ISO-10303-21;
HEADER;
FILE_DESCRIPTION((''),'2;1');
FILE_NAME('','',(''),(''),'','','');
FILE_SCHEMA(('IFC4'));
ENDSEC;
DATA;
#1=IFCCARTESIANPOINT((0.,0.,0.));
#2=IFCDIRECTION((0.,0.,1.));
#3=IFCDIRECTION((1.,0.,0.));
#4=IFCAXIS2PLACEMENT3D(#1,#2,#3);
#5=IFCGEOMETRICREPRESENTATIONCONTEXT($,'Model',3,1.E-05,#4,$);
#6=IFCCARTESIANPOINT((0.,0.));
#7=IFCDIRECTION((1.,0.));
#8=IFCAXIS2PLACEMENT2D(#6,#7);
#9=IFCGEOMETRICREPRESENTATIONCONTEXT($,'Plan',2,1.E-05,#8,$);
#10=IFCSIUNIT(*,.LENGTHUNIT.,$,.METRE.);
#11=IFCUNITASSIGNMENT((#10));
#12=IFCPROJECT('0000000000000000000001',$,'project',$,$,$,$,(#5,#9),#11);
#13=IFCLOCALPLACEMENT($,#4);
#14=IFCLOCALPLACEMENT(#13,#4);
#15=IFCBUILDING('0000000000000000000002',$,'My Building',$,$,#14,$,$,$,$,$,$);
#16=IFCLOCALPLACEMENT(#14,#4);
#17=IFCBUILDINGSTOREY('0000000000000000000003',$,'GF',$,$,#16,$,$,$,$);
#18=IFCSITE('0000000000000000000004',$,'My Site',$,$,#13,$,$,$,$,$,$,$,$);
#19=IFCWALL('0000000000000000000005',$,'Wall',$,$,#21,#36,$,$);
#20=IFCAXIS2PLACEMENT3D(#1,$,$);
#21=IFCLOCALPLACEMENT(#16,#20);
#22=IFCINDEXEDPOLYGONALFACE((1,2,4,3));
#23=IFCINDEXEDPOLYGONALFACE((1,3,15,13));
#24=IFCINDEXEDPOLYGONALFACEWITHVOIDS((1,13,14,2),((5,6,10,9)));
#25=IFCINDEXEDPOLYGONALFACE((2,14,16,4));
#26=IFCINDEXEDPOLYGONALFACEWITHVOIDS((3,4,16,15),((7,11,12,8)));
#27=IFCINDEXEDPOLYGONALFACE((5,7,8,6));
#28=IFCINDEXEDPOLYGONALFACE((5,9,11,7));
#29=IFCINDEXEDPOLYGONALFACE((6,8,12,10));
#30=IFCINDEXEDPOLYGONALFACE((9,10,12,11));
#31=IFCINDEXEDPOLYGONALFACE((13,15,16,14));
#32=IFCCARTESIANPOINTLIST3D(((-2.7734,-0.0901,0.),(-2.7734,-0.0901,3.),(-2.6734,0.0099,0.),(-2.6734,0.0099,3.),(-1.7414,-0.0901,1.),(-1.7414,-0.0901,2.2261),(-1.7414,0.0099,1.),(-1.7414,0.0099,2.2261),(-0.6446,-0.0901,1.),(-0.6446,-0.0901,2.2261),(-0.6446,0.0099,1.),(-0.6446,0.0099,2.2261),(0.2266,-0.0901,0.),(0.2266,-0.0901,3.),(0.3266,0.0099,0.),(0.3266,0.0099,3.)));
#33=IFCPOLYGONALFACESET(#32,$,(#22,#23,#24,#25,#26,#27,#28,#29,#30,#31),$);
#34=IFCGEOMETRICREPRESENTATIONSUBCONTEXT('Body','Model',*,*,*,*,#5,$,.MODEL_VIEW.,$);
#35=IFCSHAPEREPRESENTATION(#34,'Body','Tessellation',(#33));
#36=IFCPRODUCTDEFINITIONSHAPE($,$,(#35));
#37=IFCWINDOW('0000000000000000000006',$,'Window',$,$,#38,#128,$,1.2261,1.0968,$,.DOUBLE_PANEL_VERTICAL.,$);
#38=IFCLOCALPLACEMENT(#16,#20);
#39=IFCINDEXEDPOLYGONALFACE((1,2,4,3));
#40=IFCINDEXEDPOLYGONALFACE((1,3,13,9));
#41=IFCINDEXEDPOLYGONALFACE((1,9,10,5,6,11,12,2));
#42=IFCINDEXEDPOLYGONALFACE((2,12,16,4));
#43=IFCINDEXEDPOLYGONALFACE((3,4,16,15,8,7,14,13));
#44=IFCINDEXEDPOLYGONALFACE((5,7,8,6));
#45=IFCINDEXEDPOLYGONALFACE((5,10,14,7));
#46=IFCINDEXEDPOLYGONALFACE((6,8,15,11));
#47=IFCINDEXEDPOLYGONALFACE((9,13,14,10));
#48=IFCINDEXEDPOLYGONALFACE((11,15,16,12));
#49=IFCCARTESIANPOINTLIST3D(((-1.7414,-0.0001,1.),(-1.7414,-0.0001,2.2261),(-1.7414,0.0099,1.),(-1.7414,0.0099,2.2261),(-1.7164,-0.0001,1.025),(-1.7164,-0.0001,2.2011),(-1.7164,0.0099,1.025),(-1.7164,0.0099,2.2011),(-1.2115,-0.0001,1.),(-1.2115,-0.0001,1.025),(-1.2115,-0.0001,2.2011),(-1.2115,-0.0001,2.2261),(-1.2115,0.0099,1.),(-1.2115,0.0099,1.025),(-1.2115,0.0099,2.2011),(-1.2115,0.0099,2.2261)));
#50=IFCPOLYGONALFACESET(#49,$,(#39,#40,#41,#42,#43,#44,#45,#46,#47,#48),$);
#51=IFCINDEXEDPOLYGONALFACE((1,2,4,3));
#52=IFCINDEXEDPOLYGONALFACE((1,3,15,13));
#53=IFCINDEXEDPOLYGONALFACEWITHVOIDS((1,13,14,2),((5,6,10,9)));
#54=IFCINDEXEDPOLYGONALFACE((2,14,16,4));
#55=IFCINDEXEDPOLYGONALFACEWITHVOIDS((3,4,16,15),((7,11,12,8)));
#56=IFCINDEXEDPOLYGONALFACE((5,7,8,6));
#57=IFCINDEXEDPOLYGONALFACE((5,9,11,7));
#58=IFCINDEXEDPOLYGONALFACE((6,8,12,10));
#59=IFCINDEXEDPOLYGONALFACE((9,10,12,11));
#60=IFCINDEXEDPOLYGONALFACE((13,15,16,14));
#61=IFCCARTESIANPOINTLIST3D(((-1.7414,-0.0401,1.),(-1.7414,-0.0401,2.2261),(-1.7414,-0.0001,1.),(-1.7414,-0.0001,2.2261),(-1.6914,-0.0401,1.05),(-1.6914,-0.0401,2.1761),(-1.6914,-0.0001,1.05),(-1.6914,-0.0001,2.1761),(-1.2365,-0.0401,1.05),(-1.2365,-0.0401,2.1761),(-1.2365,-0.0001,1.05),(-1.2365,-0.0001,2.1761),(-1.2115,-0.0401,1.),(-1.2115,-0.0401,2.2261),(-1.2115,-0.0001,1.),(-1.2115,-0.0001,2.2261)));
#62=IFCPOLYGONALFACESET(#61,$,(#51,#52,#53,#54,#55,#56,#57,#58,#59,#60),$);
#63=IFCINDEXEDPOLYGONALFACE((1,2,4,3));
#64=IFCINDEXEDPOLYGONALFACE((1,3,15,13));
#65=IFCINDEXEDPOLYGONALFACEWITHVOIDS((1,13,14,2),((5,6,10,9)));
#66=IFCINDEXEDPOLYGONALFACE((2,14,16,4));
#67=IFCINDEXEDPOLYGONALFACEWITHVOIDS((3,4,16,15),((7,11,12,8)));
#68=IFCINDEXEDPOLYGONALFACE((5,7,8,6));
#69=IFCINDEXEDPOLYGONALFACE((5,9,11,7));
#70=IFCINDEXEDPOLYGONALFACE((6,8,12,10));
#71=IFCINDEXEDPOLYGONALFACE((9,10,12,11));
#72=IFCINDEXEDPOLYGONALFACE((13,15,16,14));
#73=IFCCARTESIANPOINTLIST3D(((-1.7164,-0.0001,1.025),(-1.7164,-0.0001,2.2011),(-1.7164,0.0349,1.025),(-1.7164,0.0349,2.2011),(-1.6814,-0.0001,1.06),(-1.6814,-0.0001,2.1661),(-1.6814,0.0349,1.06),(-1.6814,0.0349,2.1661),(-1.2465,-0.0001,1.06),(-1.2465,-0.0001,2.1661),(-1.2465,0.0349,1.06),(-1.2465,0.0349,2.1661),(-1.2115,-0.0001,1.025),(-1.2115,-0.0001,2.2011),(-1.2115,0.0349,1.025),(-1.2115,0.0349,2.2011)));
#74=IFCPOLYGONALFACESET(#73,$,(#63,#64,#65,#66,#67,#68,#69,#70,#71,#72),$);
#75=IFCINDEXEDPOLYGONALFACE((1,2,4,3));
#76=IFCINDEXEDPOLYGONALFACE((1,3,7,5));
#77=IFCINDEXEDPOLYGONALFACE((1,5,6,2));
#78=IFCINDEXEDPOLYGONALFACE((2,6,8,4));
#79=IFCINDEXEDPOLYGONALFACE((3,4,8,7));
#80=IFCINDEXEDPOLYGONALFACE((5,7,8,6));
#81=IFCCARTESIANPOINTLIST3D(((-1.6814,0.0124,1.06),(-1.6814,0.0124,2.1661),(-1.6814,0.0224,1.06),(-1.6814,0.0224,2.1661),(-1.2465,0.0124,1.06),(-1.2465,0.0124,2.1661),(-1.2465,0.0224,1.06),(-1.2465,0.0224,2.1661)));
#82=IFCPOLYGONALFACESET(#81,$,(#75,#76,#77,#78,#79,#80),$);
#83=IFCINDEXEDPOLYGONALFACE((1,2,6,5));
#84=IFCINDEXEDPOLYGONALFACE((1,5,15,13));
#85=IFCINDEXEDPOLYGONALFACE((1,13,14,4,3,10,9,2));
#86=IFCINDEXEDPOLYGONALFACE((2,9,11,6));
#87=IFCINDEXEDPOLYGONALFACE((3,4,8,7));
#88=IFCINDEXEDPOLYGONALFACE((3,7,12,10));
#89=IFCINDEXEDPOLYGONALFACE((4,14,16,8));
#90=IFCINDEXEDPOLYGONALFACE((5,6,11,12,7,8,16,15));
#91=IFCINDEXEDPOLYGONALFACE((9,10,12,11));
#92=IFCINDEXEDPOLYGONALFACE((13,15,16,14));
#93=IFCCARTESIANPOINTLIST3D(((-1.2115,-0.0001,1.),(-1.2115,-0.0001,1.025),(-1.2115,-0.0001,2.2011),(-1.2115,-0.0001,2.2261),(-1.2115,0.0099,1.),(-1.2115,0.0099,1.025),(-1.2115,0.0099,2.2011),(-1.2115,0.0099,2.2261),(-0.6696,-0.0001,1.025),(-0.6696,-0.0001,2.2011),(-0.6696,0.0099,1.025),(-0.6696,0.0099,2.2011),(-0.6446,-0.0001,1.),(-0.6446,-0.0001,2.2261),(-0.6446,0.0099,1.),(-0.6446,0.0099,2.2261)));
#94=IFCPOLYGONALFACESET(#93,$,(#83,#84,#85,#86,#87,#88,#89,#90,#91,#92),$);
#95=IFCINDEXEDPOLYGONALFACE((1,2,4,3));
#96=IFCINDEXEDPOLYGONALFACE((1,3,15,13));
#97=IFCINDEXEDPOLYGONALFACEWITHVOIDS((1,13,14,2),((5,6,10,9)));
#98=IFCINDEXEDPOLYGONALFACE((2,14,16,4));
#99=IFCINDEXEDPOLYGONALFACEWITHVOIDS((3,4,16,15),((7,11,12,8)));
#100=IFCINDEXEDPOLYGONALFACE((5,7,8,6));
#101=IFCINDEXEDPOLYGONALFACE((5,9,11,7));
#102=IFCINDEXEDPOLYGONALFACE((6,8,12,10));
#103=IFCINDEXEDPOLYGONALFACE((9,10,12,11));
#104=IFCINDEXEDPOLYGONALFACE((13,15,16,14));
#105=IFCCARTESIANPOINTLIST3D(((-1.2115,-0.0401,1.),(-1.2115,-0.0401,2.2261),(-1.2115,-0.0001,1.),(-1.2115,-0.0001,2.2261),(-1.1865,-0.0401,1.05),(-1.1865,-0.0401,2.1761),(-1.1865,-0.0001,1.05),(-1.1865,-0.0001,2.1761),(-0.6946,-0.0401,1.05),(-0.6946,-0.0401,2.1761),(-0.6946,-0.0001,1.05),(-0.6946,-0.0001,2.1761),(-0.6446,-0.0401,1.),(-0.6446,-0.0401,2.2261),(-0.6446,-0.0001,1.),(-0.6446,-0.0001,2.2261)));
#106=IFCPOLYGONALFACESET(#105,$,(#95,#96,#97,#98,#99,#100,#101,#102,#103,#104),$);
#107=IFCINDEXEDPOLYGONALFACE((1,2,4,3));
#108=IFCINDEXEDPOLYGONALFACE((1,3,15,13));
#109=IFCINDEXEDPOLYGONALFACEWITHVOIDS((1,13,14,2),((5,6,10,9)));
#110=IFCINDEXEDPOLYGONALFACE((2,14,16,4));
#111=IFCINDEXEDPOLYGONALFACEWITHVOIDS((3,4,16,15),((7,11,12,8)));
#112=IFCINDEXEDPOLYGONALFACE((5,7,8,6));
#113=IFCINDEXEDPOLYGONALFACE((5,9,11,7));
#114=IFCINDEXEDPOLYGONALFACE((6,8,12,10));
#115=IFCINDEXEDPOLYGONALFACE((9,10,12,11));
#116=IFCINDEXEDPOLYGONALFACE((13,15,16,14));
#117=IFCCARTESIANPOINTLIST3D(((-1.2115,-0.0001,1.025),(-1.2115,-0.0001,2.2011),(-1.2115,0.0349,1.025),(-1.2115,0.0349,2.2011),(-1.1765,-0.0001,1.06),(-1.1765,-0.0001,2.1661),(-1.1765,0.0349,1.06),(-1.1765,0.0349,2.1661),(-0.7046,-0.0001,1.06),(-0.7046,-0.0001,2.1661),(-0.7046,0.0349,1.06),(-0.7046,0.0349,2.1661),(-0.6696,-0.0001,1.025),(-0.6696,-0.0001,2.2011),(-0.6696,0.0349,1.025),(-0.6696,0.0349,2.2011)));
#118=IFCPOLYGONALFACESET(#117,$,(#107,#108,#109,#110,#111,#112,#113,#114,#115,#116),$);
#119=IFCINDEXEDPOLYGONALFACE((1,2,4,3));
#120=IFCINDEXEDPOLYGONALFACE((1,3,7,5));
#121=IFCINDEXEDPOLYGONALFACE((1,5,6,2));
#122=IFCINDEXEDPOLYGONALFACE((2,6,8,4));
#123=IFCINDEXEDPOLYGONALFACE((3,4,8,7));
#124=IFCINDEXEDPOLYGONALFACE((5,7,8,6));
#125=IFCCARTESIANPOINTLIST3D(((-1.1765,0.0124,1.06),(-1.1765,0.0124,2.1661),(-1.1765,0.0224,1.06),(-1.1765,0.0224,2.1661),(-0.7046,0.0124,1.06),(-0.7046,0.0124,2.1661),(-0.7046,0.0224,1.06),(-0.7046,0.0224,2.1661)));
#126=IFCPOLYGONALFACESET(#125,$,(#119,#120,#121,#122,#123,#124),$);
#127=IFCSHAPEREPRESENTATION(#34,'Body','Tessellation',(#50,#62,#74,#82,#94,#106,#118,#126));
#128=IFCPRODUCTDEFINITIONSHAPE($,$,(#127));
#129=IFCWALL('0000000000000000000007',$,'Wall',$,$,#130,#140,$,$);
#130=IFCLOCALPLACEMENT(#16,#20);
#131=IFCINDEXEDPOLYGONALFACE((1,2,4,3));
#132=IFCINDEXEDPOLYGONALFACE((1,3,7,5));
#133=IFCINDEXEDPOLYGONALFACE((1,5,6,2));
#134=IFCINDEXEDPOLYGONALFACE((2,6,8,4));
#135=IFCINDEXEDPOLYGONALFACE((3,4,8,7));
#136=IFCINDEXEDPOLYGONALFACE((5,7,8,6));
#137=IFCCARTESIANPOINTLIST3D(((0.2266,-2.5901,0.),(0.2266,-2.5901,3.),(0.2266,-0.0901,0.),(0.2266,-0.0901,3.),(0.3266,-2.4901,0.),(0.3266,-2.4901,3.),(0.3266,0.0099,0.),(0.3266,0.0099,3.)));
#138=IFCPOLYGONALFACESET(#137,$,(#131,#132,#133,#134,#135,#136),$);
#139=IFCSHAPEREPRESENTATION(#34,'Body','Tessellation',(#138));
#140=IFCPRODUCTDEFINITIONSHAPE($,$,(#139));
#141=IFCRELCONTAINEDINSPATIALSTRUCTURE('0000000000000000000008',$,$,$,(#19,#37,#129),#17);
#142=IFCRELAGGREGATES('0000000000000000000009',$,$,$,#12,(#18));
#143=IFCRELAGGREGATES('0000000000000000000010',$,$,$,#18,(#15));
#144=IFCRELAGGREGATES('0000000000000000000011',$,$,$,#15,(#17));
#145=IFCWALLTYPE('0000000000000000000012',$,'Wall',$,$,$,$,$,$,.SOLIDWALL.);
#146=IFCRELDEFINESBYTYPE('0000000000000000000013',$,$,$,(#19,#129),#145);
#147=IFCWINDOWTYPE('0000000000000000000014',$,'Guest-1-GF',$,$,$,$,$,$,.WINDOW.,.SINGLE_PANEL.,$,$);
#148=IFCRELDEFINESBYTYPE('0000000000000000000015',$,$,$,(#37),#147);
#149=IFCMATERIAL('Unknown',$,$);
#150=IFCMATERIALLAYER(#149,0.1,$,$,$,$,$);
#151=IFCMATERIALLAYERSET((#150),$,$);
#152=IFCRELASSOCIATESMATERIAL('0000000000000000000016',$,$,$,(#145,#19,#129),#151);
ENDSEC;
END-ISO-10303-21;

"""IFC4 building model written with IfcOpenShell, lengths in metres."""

from ifc_helpers import new_model, entity, si_unit, frame, origin_with_axes, origin_2d_with_axis, place, context, subcontext, project, spatial, line, indexed_curve, outline, extrude, shape, source, transform, mapped, material, layer, layer_set, layer_usage, type_object, type_shapes, element, fill, save


model = new_model("IFC4")

# Units and contexts
model_context = context("Model", 3, precision=1e-05, world=origin_with_axes())
plan_context = context("Plan", 2, precision=1e-05, world=origin_2d_with_axis())
body_context_1 = subcontext(model_context, "Body", "Model", "MODEL_VIEW")
body_context_2 = subcontext(plan_context, "Body", "Plan", "PLAN_VIEW")
ifc_project = project(units=[si_unit("LENGTHUNIT", "METRE")], contexts=[model_context, plan_context])

# Site, building, storey
site_placement = place(None, origin_with_axes())
site = spatial("IfcSite", under=ifc_project, at=site_placement, Name="My Site")
building_placement = place(site_placement, origin_with_axes())
building = spatial("IfcBuilding", under=site, at=building_placement, Name="My Building")
storey_placement = place(building_placement, origin_with_axes())
storey = spatial("IfcBuildingStorey", under=building, at=storey_placement, Name="GF")

# Shared definitions
ifc_material = material(Name="Unknown")

# Shared definitions
ifc_layer_1 = layer(ifc_material, 0.1)
ifc_layer_set_1 = layer_set([ifc_layer_1])
wall_type = type_object("IfcWallType", Name="Wall", PredefinedType="SOLIDWALL", material=ifc_layer_set_1)

# Wall, opening, window
ifc_layer_usage_1 = layer_usage(ifc_layer_set_1, "AXIS2", "POSITIVE", 0.0)
wall_1_placement = place(storey_placement, frame((-2.7734, -0.0901, 0.0), z_axis=(0.0, 0.0, 1.0), x_axis=(1.0, 0.0, 0.0)))
wall_1 = element("IfcWall", 1, at=wall_1_placement, inside=storey, type_object=wall_type, material=ifc_layer_usage_1, Name="Wall", context=body_context_1, shape_type="SweptSolid", body=[
    extrude(outline(indexed_curve([(0.0, 0.0), (0.1, 0.1), (3.1, 0.1), (3.0, 0.0)], segments=[line(1, 2, 3, 4, 1)])), origin_with_axes(), (0.0, 0.0, 1.0), 3.0),
])
shared_shape_1 = source(origin_with_axes(), body_context_1, "Body", "SweptSolid", [
    extrude(outline(indexed_curve([(0.0, 0.0), (1.0968, 0.0), (1.0968, 1.2261), (0.0, 1.2261)], segments=[line(1, 2, 3, 4, 1)])), frame((0.0, -0.6, 0.0), z_axis=(0.0, -1.0, 0.0), x_axis=(1.0, 0.0, 0.0)), (0.0, 0.0, -1.0), 1.2),
])
opening_1_placement = place(wall_1_placement, frame((1.032, 0.0, 1.0), z_axis=(0.0, 0.0, 1.0), x_axis=(1.0, 0.0, 0.0)))
opening_1 = element("IfcOpeningElement", 2, at=opening_1_placement, cuts=wall_1, PredefinedType="OPENING", context=body_context_1, shape_type="MappedRepresentation", body=[
    mapped(shared_shape_1, transform((0.0, 0.0, 0.0), x_axis=(1.0, 0.0, 0.0), y_axis=(0.0, 1.0, 0.0), z_axis=(0.0, 0.0, 1.0), scale=1.0)),
])
window_type_1 = type_object("IfcWindowType", Name="Guest-1-GF", PartitioningType="SINGLE_PANEL", PredefinedType="WINDOW")
shared_shape_2 = source(origin_with_axes(), body_context_1, "Body", "SweptSolid", [
    extrude(outline(indexed_curve([(0.5299, 0.0), (0.0, 0.0), (0.0, 1.2261), (0.5299, 1.2261), (0.5299, 1.2011), (0.025, 1.2011), (0.025, 0.025), (0.5299, 0.025)], segments=[line(1, 2, 3, 4, 5, 6, 7, 8, 1)])), frame((0.0, 0.09, 0.0), z_axis=(0.0, -1.0, 0.0), x_axis=(1.0, 0.0, 0.0)), (0.0, 0.0, -1.0), 0.01),
    extrude(outline(indexed_curve([(0.0, 0.0), (0.5299, 0.0), (0.5299, 1.2261), (0.0, 1.2261)], segments=[line(1, 2, 3, 4, 1)]), holes=[indexed_curve([(0.05, 0.05), (0.5049, 0.05), (0.5049, 1.1761), (0.05, 1.1761)], segments=[line(1, 2, 3, 4, 1)])]), frame((0.0, 0.05, 0.0), z_axis=(0.0, -1.0, 0.0), x_axis=(1.0, 0.0, 0.0)), (0.0, 0.0, -1.0), 0.04),
    extrude(outline(indexed_curve([(0.0, 0.0), (0.5049, 0.0), (0.5049, 1.1761), (0.0, 1.1761)], segments=[line(1, 2, 3, 4, 1)]), holes=[indexed_curve([(0.035, 0.035), (0.4699, 0.035), (0.4699, 1.1411), (0.035, 1.1411)], segments=[line(1, 2, 3, 4, 1)])]), frame((0.025, 0.09, 0.025), z_axis=(0.0, -1.0, 0.0), x_axis=(1.0, 0.0, 0.0)), (0.0, 0.0, -1.0), 0.035),
    extrude(outline(indexed_curve([(0.035, 0.035), (0.4699, 0.035), (0.4699, 1.1411), (0.035, 1.1411)], segments=[line(1, 2, 3, 4, 1)])), frame((0.025, 0.1025, 0.025), z_axis=(0.0, -1.0, 0.0), x_axis=(1.0, 0.0, 0.0)), (0.0, 0.0, -1.0), 0.01),
    extrude(outline(indexed_curve([(0.0, 1.2261), (0.5669, 1.2261), (0.5669, 0.0), (0.0, 0.0), (0.0, 0.025), (0.5419, 0.025), (0.5419, 1.2011), (0.0, 1.2011)], segments=[line(1, 2, 3, 4, 5, 6, 7, 8, 1)])), frame((0.5299, 0.09, 0.0), z_axis=(0.0, -1.0, 0.0), x_axis=(1.0, 0.0, 0.0)), (0.0, 0.0, -1.0), 0.01),
    extrude(outline(indexed_curve([(0.0, 0.0), (0.5669, 0.0), (0.5669, 1.2261), (0.0, 1.2261)], segments=[line(1, 2, 3, 4, 1)]), holes=[indexed_curve([(0.025, 0.05), (0.5169, 0.05), (0.5169, 1.1761), (0.025, 1.1761)], segments=[line(1, 2, 3, 4, 1)])]), frame((0.5299, 0.05, 0.0), z_axis=(0.0, -1.0, 0.0), x_axis=(1.0, 0.0, 0.0)), (0.0, 0.0, -1.0), 0.04),
    extrude(outline(indexed_curve([(0.0, 0.0), (0.5419, 0.0), (0.5419, 1.1761), (0.0, 1.1761)], segments=[line(1, 2, 3, 4, 1)]), holes=[indexed_curve([(0.035, 0.035), (0.5069, 0.035), (0.5069, 1.1411), (0.035, 1.1411)], segments=[line(1, 2, 3, 4, 1)])]), frame((0.5299, 0.09, 0.025), z_axis=(0.0, -1.0, 0.0), x_axis=(1.0, 0.0, 0.0)), (0.0, 0.0, -1.0), 0.035),
    extrude(outline(indexed_curve([(0.035, 0.035), (0.5069, 0.035), (0.5069, 1.1411), (0.035, 1.1411)], segments=[line(1, 2, 3, 4, 1)])), frame((0.5299, 0.1025, 0.025), z_axis=(0.0, -1.0, 0.0), x_axis=(1.0, 0.0, 0.0)), (0.0, 0.0, -1.0), 0.01),
])
shared_shape_3 = source(origin_with_axes(), body_context_2, "Body", "Curve2D", [
    entity("IfcIndexedPolyCurve", entity("IfcCartesianPointList2D", [[0.05, 0.05], [0.5049, 0.05]])),
    entity("IfcIndexedPolyCurve", entity("IfcCartesianPointList2D", [[0.0, 0.1], [0.025, 0.1], [0.025, 0.09], [0.05, 0.09], [0.05, 0.05], [0.0, 0.05]]), [entity("IfcLineIndex", [1, 2, 3, 4, 5, 6, 1])]),
    entity("IfcIndexedPolyCurve", entity("IfcCartesianPointList2D", [[0.5299, 0.1], [0.5299, 0.1], [0.5299, 0.09], [0.5049, 0.09], [0.5049, 0.05], [0.5299, 0.05]])),
    entity("IfcIndexedPolyCurve", entity("IfcCartesianPointList2D", [[0.025, 0.09], [0.06, 0.09], [0.06, 0.125], [0.025, 0.125]]), [entity("IfcLineIndex", [1, 2, 3, 4, 1])]),
    entity("IfcIndexedPolyCurve", entity("IfcCartesianPointList2D", [[0.5299, 0.09], [0.4949, 0.09], [0.4949, 0.125], [0.5299, 0.125]]), [entity("IfcLineIndex", [1, 2, 3, 4, 1])]),
    entity("IfcIndexedPolyCurve", entity("IfcCartesianPointList2D", [[0.06, 0.09], [0.4949, 0.09]])),
    entity("IfcIndexedPolyCurve", entity("IfcCartesianPointList2D", [[0.06, 0.125], [0.4949, 0.125]])),
    entity("IfcIndexedPolyCurve", entity("IfcCartesianPointList2D", [[0.06, 0.1075], [0.4949, 0.1075]])),
    entity("IfcIndexedPolyCurve", entity("IfcCartesianPointList2D", [[0.5549, 0.05], [1.0468, 0.05]])),
    entity("IfcIndexedPolyCurve", entity("IfcCartesianPointList2D", [[0.5299, 0.1], [0.5299, 0.1], [0.5299, 0.09], [0.5549, 0.09], [0.5549, 0.05], [0.5299, 0.05]])),
    entity("IfcIndexedPolyCurve", entity("IfcCartesianPointList2D", [[1.0968, 0.1], [1.0718, 0.1], [1.0718, 0.09], [1.0468, 0.09], [1.0468, 0.05], [1.0968, 0.05]]), [entity("IfcLineIndex", [1, 2, 3, 4, 5, 6, 1])]),
    entity("IfcIndexedPolyCurve", entity("IfcCartesianPointList2D", [[0.5299, 0.09], [0.5649, 0.09], [0.5649, 0.125], [0.5299, 0.125]]), [entity("IfcLineIndex", [1, 2, 3, 4, 1])]),
    entity("IfcIndexedPolyCurve", entity("IfcCartesianPointList2D", [[1.0718, 0.09], [1.0368, 0.09], [1.0368, 0.125], [1.0718, 0.125]]), [entity("IfcLineIndex", [1, 2, 3, 4, 1])]),
    entity("IfcIndexedPolyCurve", entity("IfcCartesianPointList2D", [[0.5649, 0.09], [1.0368, 0.09]])),
    entity("IfcIndexedPolyCurve", entity("IfcCartesianPointList2D", [[0.5649, 0.125], [1.0368, 0.125]])),
    entity("IfcIndexedPolyCurve", entity("IfcCartesianPointList2D", [[0.5649, 0.1075], [1.0368, 0.1075]])),
])
type_shapes(window_type_1, [shared_shape_2, shared_shape_3])
window_1_placement = place(opening_1_placement, origin_with_axes())
window_1 = element("IfcWindow", 3, at=window_1_placement, inside=storey, type_object=window_type_1, Name="Window", OverallHeight=1.2261, OverallWidth=1.0968, PartitioningType="DOUBLE_PANEL_VERTICAL", shapes=[
    shape(body_context_1, "Body", "MappedRepresentation", [mapped(shared_shape_2, transform((0.0, 0.0, 0.0), x_axis=(1.0, 0.0, 0.0), y_axis=(0.0, 1.0, 0.0), z_axis=(0.0, 0.0, 1.0), scale=1.0))]),
    shape(body_context_2, "Body", "MappedRepresentation", [mapped(shared_shape_3, transform((0.0, 0.0, 0.0), x_axis=(1.0, 0.0, 0.0), y_axis=(0.0, 1.0, 0.0), z_axis=(0.0, 0.0, 1.0), scale=1.0))]),
])
fill(opening_1, window_1)

# Wall
ifc_layer_usage_2 = layer_usage(ifc_layer_set_1, "AXIS2", "POSITIVE", 0.0)
wall_2_placement = place(storey_placement, frame((0.2266, -0.0901, 0.0), z_axis=(0.0, 0.0, 1.0), x_axis=(-0.000001, -1.0, 0.0)))
element("IfcWall", 4, at=wall_2_placement, inside=storey, type_object=wall_type, material=ifc_layer_usage_2, Name="Wall", context=body_context_1, shape_type="SweptSolid", body=[
    extrude(outline(indexed_curve([(0.0, 0.0), (-0.1, 0.1), (2.4, 0.1), (2.5, 0.0)], segments=[line(1, 2, 3, 4, 1)])), origin_with_axes(), (0.0, 0.0, 1.0), 3.0),
])

save(model, "model.ifc")
